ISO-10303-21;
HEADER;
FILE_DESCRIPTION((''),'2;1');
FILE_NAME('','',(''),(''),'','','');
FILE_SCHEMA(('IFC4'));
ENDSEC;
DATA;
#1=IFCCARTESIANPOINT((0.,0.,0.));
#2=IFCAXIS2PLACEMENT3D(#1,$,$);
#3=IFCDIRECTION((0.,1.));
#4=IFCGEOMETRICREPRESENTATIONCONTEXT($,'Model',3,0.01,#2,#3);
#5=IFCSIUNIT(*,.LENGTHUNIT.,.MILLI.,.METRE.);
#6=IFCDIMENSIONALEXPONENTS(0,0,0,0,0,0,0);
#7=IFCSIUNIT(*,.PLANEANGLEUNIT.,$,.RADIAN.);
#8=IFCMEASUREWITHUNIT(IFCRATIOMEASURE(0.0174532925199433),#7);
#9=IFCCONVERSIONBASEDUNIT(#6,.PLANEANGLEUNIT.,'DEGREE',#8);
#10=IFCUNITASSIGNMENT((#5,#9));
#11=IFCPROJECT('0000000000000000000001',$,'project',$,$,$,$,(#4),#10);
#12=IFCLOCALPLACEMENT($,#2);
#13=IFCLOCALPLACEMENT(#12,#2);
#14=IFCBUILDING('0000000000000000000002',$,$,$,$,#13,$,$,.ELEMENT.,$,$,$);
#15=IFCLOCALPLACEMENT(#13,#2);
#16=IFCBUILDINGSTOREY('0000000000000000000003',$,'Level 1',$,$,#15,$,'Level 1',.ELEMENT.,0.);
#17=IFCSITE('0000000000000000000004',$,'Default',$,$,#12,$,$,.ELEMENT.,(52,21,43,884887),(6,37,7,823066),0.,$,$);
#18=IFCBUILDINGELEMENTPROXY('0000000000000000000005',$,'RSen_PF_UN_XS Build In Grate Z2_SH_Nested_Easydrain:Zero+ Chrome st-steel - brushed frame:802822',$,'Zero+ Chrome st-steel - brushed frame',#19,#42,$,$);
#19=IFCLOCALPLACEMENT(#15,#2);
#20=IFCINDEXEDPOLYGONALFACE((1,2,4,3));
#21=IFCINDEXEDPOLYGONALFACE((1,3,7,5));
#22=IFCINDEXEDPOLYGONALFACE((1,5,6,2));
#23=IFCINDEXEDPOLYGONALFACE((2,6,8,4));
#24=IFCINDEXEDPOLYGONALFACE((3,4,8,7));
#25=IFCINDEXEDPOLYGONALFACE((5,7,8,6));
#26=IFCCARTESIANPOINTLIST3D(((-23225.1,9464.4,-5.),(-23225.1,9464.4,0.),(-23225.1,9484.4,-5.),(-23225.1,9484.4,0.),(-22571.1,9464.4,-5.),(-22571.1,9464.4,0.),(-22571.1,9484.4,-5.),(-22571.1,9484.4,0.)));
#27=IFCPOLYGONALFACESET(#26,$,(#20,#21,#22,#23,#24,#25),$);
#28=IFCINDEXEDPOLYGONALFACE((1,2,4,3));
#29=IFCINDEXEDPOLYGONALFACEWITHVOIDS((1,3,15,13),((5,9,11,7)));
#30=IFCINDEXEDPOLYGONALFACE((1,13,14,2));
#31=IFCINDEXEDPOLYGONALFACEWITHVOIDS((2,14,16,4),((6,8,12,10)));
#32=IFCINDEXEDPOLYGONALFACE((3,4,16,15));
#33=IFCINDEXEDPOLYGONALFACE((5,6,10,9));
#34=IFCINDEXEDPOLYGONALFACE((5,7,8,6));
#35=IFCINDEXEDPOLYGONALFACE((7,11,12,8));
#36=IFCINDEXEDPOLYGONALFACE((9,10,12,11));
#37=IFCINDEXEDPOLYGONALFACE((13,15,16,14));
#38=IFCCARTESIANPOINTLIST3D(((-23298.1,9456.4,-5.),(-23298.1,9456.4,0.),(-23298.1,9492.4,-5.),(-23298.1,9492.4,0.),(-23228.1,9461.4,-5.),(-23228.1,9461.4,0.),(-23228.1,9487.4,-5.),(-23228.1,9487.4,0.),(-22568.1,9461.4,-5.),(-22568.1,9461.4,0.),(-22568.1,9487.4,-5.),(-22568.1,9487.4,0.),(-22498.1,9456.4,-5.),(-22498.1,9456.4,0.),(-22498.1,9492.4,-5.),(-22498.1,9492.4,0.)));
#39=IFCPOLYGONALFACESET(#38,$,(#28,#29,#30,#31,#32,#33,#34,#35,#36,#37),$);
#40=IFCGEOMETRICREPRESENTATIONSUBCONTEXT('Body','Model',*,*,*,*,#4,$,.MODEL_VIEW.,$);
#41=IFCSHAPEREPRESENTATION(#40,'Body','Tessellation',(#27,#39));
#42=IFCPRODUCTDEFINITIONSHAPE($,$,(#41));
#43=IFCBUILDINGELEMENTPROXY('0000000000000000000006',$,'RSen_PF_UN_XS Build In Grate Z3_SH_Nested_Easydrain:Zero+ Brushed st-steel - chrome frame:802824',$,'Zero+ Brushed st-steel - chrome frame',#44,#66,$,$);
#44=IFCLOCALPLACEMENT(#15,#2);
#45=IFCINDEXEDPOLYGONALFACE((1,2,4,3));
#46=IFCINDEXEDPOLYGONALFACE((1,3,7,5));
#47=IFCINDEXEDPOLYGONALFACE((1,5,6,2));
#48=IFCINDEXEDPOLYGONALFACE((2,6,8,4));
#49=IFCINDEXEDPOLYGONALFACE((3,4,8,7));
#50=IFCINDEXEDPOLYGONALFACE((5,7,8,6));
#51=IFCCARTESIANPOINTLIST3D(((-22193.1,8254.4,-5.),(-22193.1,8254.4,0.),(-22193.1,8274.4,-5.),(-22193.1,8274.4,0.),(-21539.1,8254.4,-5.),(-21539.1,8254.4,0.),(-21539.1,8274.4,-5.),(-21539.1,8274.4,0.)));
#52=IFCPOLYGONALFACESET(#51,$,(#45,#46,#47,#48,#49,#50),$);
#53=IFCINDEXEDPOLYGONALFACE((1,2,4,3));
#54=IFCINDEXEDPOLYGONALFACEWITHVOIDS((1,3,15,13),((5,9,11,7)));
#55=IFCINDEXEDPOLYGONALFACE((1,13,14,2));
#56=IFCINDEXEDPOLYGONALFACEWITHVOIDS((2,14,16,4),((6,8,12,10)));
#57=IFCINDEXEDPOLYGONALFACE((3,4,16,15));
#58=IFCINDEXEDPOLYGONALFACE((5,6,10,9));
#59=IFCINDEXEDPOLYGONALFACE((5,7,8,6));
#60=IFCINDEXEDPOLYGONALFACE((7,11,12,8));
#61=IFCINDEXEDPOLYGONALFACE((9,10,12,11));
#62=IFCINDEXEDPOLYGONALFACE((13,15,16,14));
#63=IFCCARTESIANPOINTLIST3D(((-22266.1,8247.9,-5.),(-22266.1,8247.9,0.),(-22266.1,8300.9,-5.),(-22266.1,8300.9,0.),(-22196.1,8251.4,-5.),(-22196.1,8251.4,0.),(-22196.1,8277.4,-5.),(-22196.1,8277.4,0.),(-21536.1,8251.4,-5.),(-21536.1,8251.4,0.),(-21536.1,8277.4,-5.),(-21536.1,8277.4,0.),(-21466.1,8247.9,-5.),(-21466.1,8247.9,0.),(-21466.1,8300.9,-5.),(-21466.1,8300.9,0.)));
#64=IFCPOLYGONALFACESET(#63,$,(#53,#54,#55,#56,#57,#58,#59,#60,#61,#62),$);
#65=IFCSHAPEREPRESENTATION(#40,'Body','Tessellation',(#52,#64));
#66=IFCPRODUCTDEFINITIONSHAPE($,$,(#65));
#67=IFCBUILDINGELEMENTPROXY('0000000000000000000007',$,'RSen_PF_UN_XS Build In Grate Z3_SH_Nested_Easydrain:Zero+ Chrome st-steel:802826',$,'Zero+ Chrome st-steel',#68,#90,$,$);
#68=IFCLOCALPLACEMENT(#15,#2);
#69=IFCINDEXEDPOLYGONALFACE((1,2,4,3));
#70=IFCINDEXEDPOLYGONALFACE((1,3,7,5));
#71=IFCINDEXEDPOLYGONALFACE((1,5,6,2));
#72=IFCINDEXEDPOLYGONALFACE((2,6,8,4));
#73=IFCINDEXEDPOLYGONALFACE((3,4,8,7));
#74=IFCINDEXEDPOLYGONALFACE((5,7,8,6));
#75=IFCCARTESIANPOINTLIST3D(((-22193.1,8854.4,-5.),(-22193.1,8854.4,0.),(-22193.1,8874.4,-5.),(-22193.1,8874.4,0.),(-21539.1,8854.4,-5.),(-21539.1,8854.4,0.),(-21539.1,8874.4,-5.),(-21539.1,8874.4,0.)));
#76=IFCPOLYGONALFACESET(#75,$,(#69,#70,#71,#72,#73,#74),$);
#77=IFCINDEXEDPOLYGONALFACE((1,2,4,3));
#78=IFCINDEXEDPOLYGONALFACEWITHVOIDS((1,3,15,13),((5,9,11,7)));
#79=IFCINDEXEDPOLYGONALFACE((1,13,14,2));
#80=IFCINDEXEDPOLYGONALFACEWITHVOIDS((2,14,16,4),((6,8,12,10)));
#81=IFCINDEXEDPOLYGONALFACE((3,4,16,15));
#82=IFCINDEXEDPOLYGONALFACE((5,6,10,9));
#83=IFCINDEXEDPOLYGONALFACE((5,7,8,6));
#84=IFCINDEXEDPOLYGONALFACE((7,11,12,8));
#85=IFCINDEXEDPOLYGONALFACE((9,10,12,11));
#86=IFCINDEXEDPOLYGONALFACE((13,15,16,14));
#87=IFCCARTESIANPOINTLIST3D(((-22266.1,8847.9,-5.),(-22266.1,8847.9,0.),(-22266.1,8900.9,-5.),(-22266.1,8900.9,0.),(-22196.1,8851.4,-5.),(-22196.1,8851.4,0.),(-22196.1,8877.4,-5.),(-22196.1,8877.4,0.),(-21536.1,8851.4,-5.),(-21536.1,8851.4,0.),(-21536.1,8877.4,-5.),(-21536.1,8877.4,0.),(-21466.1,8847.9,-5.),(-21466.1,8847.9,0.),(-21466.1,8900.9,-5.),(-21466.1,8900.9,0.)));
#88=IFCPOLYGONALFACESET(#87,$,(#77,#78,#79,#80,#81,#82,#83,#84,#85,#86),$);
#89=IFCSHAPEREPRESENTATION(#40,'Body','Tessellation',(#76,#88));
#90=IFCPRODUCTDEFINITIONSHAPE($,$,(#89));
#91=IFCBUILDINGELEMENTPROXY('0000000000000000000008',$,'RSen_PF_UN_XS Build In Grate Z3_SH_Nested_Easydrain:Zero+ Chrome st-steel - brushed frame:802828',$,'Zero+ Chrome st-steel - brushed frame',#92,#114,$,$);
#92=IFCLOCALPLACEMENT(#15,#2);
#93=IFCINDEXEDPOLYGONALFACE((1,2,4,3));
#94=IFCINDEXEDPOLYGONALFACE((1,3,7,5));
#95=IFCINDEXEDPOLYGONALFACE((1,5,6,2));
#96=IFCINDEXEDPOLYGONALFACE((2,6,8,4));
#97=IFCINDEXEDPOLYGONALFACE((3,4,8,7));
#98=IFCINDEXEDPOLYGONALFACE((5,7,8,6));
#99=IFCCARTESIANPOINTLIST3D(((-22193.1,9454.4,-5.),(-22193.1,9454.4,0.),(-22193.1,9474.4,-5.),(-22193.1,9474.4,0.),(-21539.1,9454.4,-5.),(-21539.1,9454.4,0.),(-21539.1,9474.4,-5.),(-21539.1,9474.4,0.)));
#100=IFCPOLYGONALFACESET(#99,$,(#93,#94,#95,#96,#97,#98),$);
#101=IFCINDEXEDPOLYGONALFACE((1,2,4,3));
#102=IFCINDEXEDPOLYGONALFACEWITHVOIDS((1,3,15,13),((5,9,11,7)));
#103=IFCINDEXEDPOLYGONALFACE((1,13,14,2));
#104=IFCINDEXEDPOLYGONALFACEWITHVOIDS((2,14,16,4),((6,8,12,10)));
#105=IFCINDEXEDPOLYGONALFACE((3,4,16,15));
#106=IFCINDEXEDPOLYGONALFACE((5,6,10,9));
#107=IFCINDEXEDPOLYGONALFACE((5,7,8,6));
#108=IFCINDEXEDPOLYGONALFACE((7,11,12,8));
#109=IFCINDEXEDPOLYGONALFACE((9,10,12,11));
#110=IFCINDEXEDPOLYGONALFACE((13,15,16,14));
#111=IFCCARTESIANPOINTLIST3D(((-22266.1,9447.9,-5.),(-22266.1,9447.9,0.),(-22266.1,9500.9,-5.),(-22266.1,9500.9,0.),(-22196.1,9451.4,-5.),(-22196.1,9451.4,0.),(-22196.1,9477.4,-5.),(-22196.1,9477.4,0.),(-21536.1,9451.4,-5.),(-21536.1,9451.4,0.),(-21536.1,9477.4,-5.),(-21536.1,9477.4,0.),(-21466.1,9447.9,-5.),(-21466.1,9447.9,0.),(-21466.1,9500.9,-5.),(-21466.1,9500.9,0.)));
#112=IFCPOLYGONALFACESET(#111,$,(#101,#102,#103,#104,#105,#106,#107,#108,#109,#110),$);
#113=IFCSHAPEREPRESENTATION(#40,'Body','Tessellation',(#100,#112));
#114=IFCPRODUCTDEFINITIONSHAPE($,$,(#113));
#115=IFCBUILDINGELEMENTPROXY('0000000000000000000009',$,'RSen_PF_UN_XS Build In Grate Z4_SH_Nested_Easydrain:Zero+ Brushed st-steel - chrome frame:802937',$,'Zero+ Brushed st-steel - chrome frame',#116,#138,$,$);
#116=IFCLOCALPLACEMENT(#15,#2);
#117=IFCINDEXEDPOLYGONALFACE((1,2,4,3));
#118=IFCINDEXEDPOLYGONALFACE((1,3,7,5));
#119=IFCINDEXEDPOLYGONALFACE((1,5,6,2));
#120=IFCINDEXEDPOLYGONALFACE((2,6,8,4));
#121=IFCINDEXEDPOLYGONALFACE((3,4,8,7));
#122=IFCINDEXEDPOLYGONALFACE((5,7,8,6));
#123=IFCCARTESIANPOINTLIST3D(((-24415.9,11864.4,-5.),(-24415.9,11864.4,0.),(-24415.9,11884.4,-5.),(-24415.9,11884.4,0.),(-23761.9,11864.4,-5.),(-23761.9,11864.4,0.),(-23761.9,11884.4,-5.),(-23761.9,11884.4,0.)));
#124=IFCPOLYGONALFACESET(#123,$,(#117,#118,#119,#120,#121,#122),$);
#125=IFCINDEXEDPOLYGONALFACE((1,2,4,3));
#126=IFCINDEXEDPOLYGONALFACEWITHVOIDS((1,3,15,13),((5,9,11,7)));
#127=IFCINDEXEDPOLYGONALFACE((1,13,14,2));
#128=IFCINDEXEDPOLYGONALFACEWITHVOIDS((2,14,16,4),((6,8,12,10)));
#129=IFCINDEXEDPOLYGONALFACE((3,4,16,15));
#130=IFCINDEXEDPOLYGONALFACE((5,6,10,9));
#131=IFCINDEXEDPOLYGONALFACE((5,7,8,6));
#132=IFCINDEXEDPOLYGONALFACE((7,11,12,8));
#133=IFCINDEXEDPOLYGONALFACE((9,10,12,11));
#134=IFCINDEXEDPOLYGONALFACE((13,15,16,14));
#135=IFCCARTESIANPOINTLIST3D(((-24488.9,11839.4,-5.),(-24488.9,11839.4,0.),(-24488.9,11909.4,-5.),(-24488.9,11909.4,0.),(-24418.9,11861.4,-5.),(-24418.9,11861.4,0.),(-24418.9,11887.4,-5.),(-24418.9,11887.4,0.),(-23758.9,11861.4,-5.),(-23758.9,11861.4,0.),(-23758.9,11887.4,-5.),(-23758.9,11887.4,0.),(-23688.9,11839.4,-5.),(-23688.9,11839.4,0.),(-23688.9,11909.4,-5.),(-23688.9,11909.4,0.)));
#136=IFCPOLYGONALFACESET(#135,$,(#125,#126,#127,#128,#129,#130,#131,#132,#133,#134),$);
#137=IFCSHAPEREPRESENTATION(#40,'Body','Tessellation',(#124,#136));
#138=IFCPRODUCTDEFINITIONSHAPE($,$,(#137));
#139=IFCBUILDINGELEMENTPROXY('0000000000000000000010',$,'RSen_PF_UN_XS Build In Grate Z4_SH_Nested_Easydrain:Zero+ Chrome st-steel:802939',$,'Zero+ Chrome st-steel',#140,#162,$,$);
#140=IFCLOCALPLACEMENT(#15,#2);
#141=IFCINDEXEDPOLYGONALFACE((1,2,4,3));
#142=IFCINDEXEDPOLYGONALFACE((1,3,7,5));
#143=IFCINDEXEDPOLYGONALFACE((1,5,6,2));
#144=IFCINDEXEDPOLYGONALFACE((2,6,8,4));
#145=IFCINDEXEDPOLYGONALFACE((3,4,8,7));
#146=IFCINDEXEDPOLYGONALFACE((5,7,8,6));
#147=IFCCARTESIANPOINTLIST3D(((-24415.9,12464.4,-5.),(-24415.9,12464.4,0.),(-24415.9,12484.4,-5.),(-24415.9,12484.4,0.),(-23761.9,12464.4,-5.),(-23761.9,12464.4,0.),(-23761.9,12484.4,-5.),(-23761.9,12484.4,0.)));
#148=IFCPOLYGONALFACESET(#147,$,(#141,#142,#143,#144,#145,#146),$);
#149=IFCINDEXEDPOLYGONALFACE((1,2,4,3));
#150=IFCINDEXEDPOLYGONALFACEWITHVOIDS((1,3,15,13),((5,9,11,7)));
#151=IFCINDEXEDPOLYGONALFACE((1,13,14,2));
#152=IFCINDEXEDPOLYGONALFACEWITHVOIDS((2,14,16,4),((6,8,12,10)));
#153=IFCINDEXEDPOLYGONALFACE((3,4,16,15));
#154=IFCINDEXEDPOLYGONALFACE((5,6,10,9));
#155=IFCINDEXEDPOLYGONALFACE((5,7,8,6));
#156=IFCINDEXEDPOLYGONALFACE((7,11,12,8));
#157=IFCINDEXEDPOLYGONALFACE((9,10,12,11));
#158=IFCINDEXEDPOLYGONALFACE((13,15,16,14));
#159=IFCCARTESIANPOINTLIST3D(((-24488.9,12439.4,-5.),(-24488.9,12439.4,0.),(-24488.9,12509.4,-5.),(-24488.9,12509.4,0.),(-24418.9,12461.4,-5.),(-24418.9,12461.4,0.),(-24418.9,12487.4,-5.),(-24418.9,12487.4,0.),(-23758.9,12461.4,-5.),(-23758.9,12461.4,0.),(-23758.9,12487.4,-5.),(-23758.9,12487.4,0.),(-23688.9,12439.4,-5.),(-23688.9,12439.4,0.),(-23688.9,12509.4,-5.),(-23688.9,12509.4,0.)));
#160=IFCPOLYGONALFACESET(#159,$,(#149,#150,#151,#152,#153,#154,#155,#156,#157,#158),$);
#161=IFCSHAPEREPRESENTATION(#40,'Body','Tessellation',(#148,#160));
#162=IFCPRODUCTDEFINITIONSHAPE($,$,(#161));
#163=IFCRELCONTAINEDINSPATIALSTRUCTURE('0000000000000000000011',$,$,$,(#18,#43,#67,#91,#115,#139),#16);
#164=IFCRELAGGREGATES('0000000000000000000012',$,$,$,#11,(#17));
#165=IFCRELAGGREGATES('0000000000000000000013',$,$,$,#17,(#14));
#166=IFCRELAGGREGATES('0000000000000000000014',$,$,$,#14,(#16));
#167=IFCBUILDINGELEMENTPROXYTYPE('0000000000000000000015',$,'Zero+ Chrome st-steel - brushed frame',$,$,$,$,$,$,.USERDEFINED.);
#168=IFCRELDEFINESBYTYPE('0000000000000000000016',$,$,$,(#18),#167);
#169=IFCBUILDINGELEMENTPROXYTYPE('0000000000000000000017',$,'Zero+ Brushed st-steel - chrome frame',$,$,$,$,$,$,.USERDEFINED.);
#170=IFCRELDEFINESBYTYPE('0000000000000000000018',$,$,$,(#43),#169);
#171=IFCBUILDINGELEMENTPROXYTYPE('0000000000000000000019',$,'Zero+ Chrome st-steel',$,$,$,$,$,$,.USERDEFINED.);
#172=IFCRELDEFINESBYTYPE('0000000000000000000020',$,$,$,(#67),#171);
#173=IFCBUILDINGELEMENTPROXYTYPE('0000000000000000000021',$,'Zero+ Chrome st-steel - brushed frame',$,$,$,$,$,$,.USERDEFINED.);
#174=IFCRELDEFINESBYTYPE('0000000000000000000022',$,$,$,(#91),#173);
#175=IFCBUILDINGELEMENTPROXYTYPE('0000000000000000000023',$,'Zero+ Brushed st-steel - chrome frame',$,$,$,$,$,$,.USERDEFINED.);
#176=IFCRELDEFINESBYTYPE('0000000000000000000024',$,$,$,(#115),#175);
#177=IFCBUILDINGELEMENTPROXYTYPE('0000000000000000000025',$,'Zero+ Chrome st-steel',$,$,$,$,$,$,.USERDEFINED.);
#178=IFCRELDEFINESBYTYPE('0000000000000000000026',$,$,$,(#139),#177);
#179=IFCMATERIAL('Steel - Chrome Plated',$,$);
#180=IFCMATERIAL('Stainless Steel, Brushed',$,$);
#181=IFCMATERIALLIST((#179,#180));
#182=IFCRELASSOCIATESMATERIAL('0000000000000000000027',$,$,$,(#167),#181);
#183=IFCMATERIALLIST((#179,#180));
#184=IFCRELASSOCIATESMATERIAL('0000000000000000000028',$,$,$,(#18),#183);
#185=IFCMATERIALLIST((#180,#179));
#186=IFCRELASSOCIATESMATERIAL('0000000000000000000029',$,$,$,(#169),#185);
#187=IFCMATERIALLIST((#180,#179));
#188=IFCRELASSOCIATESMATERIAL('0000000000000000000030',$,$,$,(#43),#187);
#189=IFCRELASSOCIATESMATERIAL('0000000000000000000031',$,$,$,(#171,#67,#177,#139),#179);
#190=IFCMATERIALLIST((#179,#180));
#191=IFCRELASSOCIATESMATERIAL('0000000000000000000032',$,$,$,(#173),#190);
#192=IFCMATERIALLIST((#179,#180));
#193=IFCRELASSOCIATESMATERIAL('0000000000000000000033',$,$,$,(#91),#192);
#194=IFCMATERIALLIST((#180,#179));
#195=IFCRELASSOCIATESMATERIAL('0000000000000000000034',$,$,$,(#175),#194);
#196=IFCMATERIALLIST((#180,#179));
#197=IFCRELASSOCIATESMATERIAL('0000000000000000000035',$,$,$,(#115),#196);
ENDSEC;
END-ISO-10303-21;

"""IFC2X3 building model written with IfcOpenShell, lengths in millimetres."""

from ifc_helpers import new_model, entity, si_unit, converted_unit, direction, frame, origin, origin_2d_with_axis, place, context, subcontext, project, spatial, polyline, rectangle, outline, extrude, source, transform, mapped, material, material_list, type_object, type_shapes, element, save


model = new_model("IFC2X3")

# Units and contexts
model_context = context("Model", 3, precision=0.01, world=origin(), true_north=direction((0.0, 1.0)))
body_context = subcontext(model_context, "Body", "Model", "MODEL_VIEW")
ifc_project = project(units=[si_unit("LENGTHUNIT", "METRE", prefix="MILLI"), converted_unit("PLANEANGLEUNIT", "DEGREE", entity("IfcRatioMeasure", 0.0174532925199433), si_unit("PLANEANGLEUNIT", "RADIAN"), dimensions=[0, 0, 0, 0, 0, 0, 0])], contexts=[model_context])

# Site, building, storey
site_placement = place(None, origin())
site = spatial("IfcSite", under=ifc_project, at=site_placement, Name="Default", CompositionType="ELEMENT", RefLatitude=(52, 21, 43, 884887), RefLongitude=(6, 37, 7, 823066), RefElevation=0.0)
building_placement = place(site_placement, origin())
building = spatial("IfcBuilding", under=site, at=building_placement, CompositionType="ELEMENT")
storey_placement = place(building_placement, origin())
storey = spatial("IfcBuildingStorey", under=building, at=storey_placement, Name="Level 1", LongName="Level 1", CompositionType="ELEMENT", Elevation=0.0)

# Shared definitions
ifc_material_1 = material(Name="Stainless Steel, Brushed")

# Building element proxies
ifc_material_2 = material(Name="Steel - Chrome Plated")
ifc_material_list_1 = material_list([ifc_material_2, ifc_material_1])
ifc_material_list_2 = material_list([ifc_material_2, ifc_material_1])
building_element_proxy_type_1 = type_object("IfcBuildingElementProxyType", Name="Zero+ Chrome st-steel - brushed frame", PredefinedType="USERDEFINED", material=ifc_material_list_2)
shared_shape_1 = source(origin(), body_context, "Body", "SweptSolid", [
    extrude(rectangle(XDim=654.0, YDim=20.0, at=origin_2d_with_axis()), frame((0.0, 0.0, 0.0), z_axis=(0.0, 0.0, 1.0), x_axis=(-1.0, 0.0, 0.0)), (0.0, 0.0, 1.0), 5.0),
    extrude(outline(polyline([(-400.0, -18.0), (400.0, -18.0), (400.0, 18.0), (-400.0, 18.0), (-400.0, -18.0)]), holes=[polyline([(-330.0, -13.0), (-330.0, 13.0), (330.0, 13.0), (330.0, -13.0), (-330.0, -13.0)])]), frame((0.0, 0.0, 0.0), z_axis=(0.0, 0.0, 1.0), x_axis=(-1.0, 0.0, 0.0)), (0.0, 0.0, 1.0), 5.0),
])
type_shapes(building_element_proxy_type_1, [shared_shape_1])
proxy_1_placement = place(storey_placement, frame((-22898.1, 9474.4, -5.0)))
element("IfcBuildingElementProxy", 1, at=proxy_1_placement, inside=storey, type_object=building_element_proxy_type_1, material=ifc_material_list_1, Name="RSen_PF_UN_XS Build In Grate Z2_SH_Nested_Easydrain:Zero+ Chrome st-steel - brushed frame:802822", ObjectType="Zero+ Chrome st-steel - brushed frame", context=body_context, shape_type="MappedRepresentation", body=[
    mapped(shared_shape_1, transform((0.0, 0.0, 0.0), scale=1.0)),
])
ifc_material_list_3 = material_list([ifc_material_1, ifc_material_2])
ifc_material_list_4 = material_list([ifc_material_1, ifc_material_2])
building_element_proxy_type_2 = type_object("IfcBuildingElementProxyType", Name="Zero+ Brushed st-steel - chrome frame", PredefinedType="USERDEFINED", material=ifc_material_list_4)
shared_shape_2 = source(origin(), body_context, "Body", "SweptSolid", [
    extrude(rectangle(XDim=654.0, YDim=20.0, at=origin_2d_with_axis()), frame((0.0, -10.0, 0.0), z_axis=(0.0, 0.0, 1.0), x_axis=(-1.0, 0.0, 0.0)), (0.0, 0.0, 1.0), 5.0),
    extrude(outline(polyline([(-400.0, -26.5), (400.0, -26.5), (400.0, 26.5), (-400.0, 26.5), (-400.0, -26.5)]), holes=[polyline([(-330.0, -3.0), (-330.0, 23.0), (330.0, 23.0), (330.0, -3.0), (-330.0, -3.0)])]), frame((0.0, 0.0, 0.0), z_axis=(0.0, 0.0, 1.0), x_axis=(-1.0, 0.0, 0.0)), (0.0, 0.0, 1.0), 5.0),
])
type_shapes(building_element_proxy_type_2, [shared_shape_2])
proxy_2_placement = place(storey_placement, frame((-21866.1, 8274.4, -5.0)))
element("IfcBuildingElementProxy", 2, at=proxy_2_placement, inside=storey, type_object=building_element_proxy_type_2, material=ifc_material_list_3, Name="RSen_PF_UN_XS Build In Grate Z3_SH_Nested_Easydrain:Zero+ Brushed st-steel - chrome frame:802824", ObjectType="Zero+ Brushed st-steel - chrome frame", context=body_context, shape_type="MappedRepresentation", body=[
    mapped(shared_shape_2, transform((0.0, 0.0, 0.0), scale=1.0)),
])
building_element_proxy_type_3 = type_object("IfcBuildingElementProxyType", Name="Zero+ Chrome st-steel", PredefinedType="USERDEFINED", material=ifc_material_2)
shared_shape_3 = source(origin(), body_context, "Body", "SweptSolid", [
    extrude(rectangle(XDim=654.0, YDim=20.0, at=origin_2d_with_axis()), frame((0.0, -10.0, 0.0), z_axis=(0.0, 0.0, 1.0), x_axis=(-1.0, 0.0, 0.0)), (0.0, 0.0, 1.0), 5.0),
    extrude(outline(polyline([(-400.0, -26.5), (400.0, -26.5), (400.0, 26.5), (-400.0, 26.5), (-400.0, -26.5)]), holes=[polyline([(-330.0, -3.0), (-330.0, 23.0), (330.0, 23.0), (330.0, -3.0), (-330.0, -3.0)])]), frame((0.0, 0.0, 0.0), z_axis=(0.0, 0.0, 1.0), x_axis=(-1.0, 0.0, 0.0)), (0.0, 0.0, 1.0), 5.0),
])
type_shapes(building_element_proxy_type_3, [shared_shape_3])
proxy_3_placement = place(storey_placement, frame((-21866.1, 8874.4, -5.0)))
element("IfcBuildingElementProxy", 3, at=proxy_3_placement, inside=storey, type_object=building_element_proxy_type_3, material=ifc_material_2, Name="RSen_PF_UN_XS Build In Grate Z3_SH_Nested_Easydrain:Zero+ Chrome st-steel:802826", ObjectType="Zero+ Chrome st-steel", context=body_context, shape_type="MappedRepresentation", body=[
    mapped(shared_shape_3, transform((0.0, 0.0, 0.0), scale=1.0)),
])
ifc_material_list_5 = material_list([ifc_material_2, ifc_material_1])
ifc_material_list_6 = material_list([ifc_material_2, ifc_material_1])
building_element_proxy_type_4 = type_object("IfcBuildingElementProxyType", Name="Zero+ Chrome st-steel - brushed frame", PredefinedType="USERDEFINED", material=ifc_material_list_6)
shared_shape_4 = source(origin(), body_context, "Body", "SweptSolid", [
    extrude(rectangle(XDim=654.0, YDim=20.0, at=origin_2d_with_axis()), frame((0.0, -10.0, 0.0), z_axis=(0.0, 0.0, 1.0), x_axis=(-1.0, 0.0, 0.0)), (0.0, 0.0, 1.0), 5.0),
    extrude(outline(polyline([(-400.0, -26.5), (400.0, -26.5), (400.0, 26.5), (-400.0, 26.5), (-400.0, -26.5)]), holes=[polyline([(-330.0, -3.0), (-330.0, 23.0), (330.0, 23.0), (330.0, -3.0), (-330.0, -3.0)])]), frame((0.0, 0.0, 0.0), z_axis=(0.0, 0.0, 1.0), x_axis=(-1.0, 0.0, 0.0)), (0.0, 0.0, 1.0), 5.0),
])
type_shapes(building_element_proxy_type_4, [shared_shape_4])
proxy_4_placement = place(storey_placement, frame((-21866.1, 9474.4, -5.0)))
element("IfcBuildingElementProxy", 4, at=proxy_4_placement, inside=storey, type_object=building_element_proxy_type_4, material=ifc_material_list_5, Name="RSen_PF_UN_XS Build In Grate Z3_SH_Nested_Easydrain:Zero+ Chrome st-steel - brushed frame:802828", ObjectType="Zero+ Chrome st-steel - brushed frame", context=body_context, shape_type="MappedRepresentation", body=[
    mapped(shared_shape_4, transform((0.0, 0.0, 0.0), scale=1.0)),
])
ifc_material_list_7 = material_list([ifc_material_1, ifc_material_2])
ifc_material_list_8 = material_list([ifc_material_1, ifc_material_2])
building_element_proxy_type_5 = type_object("IfcBuildingElementProxyType", Name="Zero+ Brushed st-steel - chrome frame", PredefinedType="USERDEFINED", material=ifc_material_list_8)
shared_shape_5 = source(origin(), body_context, "Body", "SweptSolid", [
    extrude(rectangle(XDim=654.0, YDim=20.0, at=origin_2d_with_axis()), frame((0.0, 0.0, 0.0), z_axis=(0.0, 0.0, 1.0), x_axis=(-1.0, 0.0, 0.0)), (0.0, 0.0, 1.0), 5.0),
    extrude(outline(polyline([(-400.0, -35.0), (400.0, -35.0), (400.0, 35.0), (-400.0, 35.0), (-400.0, -35.0)]), holes=[polyline([(-330.0, -13.0), (-330.0, 13.0), (330.0, 13.0), (330.0, -13.0), (-330.0, -13.0)])]), frame((0.0, 0.0, 0.0), z_axis=(0.0, 0.0, 1.0), x_axis=(-1.0, 0.0, 0.0)), (0.0, 0.0, 1.0), 5.0),
])
type_shapes(building_element_proxy_type_5, [shared_shape_5])
proxy_5_placement = place(storey_placement, frame((-24088.9, 11874.4, -5.0)))
element("IfcBuildingElementProxy", 5, at=proxy_5_placement, inside=storey, type_object=building_element_proxy_type_5, material=ifc_material_list_7, Name="RSen_PF_UN_XS Build In Grate Z4_SH_Nested_Easydrain:Zero+ Brushed st-steel - chrome frame:802937", ObjectType="Zero+ Brushed st-steel - chrome frame", context=body_context, shape_type="MappedRepresentation", body=[
    mapped(shared_shape_5, transform((0.0, 0.0, 0.0), scale=1.0)),
])
building_element_proxy_type_6 = type_object("IfcBuildingElementProxyType", Name="Zero+ Chrome st-steel", PredefinedType="USERDEFINED", material=ifc_material_2)
shared_shape_6 = source(origin(), body_context, "Body", "SweptSolid", [
    extrude(rectangle(XDim=654.0, YDim=20.0, at=origin_2d_with_axis()), frame((0.0, 0.0, 0.0), z_axis=(0.0, 0.0, 1.0), x_axis=(-1.0, 0.0, 0.0)), (0.0, 0.0, 1.0), 5.0),
    extrude(outline(polyline([(-400.0, -35.0), (400.0, -35.0), (400.0, 35.0), (-400.0, 35.0), (-400.0, -35.0)]), holes=[polyline([(-330.0, -13.0), (-330.0, 13.0), (330.0, 13.0), (330.0, -13.0), (-330.0, -13.0)])]), frame((0.0, 0.0, 0.0), z_axis=(0.0, 0.0, 1.0), x_axis=(-1.0, 0.0, 0.0)), (0.0, 0.0, 1.0), 5.0),
])
type_shapes(building_element_proxy_type_6, [shared_shape_6])
proxy_6_placement = place(storey_placement, frame((-24088.9, 12474.4, -5.0)))
element("IfcBuildingElementProxy", 6, at=proxy_6_placement, inside=storey, type_object=building_element_proxy_type_6, material=ifc_material_2, Name="RSen_PF_UN_XS Build In Grate Z4_SH_Nested_Easydrain:Zero+ Chrome st-steel:802939", ObjectType="Zero+ Chrome st-steel", context=body_context, shape_type="MappedRepresentation", body=[
    mapped(shared_shape_6, transform((0.0, 0.0, 0.0), scale=1.0)),
])

save(model, "model.ifc")
